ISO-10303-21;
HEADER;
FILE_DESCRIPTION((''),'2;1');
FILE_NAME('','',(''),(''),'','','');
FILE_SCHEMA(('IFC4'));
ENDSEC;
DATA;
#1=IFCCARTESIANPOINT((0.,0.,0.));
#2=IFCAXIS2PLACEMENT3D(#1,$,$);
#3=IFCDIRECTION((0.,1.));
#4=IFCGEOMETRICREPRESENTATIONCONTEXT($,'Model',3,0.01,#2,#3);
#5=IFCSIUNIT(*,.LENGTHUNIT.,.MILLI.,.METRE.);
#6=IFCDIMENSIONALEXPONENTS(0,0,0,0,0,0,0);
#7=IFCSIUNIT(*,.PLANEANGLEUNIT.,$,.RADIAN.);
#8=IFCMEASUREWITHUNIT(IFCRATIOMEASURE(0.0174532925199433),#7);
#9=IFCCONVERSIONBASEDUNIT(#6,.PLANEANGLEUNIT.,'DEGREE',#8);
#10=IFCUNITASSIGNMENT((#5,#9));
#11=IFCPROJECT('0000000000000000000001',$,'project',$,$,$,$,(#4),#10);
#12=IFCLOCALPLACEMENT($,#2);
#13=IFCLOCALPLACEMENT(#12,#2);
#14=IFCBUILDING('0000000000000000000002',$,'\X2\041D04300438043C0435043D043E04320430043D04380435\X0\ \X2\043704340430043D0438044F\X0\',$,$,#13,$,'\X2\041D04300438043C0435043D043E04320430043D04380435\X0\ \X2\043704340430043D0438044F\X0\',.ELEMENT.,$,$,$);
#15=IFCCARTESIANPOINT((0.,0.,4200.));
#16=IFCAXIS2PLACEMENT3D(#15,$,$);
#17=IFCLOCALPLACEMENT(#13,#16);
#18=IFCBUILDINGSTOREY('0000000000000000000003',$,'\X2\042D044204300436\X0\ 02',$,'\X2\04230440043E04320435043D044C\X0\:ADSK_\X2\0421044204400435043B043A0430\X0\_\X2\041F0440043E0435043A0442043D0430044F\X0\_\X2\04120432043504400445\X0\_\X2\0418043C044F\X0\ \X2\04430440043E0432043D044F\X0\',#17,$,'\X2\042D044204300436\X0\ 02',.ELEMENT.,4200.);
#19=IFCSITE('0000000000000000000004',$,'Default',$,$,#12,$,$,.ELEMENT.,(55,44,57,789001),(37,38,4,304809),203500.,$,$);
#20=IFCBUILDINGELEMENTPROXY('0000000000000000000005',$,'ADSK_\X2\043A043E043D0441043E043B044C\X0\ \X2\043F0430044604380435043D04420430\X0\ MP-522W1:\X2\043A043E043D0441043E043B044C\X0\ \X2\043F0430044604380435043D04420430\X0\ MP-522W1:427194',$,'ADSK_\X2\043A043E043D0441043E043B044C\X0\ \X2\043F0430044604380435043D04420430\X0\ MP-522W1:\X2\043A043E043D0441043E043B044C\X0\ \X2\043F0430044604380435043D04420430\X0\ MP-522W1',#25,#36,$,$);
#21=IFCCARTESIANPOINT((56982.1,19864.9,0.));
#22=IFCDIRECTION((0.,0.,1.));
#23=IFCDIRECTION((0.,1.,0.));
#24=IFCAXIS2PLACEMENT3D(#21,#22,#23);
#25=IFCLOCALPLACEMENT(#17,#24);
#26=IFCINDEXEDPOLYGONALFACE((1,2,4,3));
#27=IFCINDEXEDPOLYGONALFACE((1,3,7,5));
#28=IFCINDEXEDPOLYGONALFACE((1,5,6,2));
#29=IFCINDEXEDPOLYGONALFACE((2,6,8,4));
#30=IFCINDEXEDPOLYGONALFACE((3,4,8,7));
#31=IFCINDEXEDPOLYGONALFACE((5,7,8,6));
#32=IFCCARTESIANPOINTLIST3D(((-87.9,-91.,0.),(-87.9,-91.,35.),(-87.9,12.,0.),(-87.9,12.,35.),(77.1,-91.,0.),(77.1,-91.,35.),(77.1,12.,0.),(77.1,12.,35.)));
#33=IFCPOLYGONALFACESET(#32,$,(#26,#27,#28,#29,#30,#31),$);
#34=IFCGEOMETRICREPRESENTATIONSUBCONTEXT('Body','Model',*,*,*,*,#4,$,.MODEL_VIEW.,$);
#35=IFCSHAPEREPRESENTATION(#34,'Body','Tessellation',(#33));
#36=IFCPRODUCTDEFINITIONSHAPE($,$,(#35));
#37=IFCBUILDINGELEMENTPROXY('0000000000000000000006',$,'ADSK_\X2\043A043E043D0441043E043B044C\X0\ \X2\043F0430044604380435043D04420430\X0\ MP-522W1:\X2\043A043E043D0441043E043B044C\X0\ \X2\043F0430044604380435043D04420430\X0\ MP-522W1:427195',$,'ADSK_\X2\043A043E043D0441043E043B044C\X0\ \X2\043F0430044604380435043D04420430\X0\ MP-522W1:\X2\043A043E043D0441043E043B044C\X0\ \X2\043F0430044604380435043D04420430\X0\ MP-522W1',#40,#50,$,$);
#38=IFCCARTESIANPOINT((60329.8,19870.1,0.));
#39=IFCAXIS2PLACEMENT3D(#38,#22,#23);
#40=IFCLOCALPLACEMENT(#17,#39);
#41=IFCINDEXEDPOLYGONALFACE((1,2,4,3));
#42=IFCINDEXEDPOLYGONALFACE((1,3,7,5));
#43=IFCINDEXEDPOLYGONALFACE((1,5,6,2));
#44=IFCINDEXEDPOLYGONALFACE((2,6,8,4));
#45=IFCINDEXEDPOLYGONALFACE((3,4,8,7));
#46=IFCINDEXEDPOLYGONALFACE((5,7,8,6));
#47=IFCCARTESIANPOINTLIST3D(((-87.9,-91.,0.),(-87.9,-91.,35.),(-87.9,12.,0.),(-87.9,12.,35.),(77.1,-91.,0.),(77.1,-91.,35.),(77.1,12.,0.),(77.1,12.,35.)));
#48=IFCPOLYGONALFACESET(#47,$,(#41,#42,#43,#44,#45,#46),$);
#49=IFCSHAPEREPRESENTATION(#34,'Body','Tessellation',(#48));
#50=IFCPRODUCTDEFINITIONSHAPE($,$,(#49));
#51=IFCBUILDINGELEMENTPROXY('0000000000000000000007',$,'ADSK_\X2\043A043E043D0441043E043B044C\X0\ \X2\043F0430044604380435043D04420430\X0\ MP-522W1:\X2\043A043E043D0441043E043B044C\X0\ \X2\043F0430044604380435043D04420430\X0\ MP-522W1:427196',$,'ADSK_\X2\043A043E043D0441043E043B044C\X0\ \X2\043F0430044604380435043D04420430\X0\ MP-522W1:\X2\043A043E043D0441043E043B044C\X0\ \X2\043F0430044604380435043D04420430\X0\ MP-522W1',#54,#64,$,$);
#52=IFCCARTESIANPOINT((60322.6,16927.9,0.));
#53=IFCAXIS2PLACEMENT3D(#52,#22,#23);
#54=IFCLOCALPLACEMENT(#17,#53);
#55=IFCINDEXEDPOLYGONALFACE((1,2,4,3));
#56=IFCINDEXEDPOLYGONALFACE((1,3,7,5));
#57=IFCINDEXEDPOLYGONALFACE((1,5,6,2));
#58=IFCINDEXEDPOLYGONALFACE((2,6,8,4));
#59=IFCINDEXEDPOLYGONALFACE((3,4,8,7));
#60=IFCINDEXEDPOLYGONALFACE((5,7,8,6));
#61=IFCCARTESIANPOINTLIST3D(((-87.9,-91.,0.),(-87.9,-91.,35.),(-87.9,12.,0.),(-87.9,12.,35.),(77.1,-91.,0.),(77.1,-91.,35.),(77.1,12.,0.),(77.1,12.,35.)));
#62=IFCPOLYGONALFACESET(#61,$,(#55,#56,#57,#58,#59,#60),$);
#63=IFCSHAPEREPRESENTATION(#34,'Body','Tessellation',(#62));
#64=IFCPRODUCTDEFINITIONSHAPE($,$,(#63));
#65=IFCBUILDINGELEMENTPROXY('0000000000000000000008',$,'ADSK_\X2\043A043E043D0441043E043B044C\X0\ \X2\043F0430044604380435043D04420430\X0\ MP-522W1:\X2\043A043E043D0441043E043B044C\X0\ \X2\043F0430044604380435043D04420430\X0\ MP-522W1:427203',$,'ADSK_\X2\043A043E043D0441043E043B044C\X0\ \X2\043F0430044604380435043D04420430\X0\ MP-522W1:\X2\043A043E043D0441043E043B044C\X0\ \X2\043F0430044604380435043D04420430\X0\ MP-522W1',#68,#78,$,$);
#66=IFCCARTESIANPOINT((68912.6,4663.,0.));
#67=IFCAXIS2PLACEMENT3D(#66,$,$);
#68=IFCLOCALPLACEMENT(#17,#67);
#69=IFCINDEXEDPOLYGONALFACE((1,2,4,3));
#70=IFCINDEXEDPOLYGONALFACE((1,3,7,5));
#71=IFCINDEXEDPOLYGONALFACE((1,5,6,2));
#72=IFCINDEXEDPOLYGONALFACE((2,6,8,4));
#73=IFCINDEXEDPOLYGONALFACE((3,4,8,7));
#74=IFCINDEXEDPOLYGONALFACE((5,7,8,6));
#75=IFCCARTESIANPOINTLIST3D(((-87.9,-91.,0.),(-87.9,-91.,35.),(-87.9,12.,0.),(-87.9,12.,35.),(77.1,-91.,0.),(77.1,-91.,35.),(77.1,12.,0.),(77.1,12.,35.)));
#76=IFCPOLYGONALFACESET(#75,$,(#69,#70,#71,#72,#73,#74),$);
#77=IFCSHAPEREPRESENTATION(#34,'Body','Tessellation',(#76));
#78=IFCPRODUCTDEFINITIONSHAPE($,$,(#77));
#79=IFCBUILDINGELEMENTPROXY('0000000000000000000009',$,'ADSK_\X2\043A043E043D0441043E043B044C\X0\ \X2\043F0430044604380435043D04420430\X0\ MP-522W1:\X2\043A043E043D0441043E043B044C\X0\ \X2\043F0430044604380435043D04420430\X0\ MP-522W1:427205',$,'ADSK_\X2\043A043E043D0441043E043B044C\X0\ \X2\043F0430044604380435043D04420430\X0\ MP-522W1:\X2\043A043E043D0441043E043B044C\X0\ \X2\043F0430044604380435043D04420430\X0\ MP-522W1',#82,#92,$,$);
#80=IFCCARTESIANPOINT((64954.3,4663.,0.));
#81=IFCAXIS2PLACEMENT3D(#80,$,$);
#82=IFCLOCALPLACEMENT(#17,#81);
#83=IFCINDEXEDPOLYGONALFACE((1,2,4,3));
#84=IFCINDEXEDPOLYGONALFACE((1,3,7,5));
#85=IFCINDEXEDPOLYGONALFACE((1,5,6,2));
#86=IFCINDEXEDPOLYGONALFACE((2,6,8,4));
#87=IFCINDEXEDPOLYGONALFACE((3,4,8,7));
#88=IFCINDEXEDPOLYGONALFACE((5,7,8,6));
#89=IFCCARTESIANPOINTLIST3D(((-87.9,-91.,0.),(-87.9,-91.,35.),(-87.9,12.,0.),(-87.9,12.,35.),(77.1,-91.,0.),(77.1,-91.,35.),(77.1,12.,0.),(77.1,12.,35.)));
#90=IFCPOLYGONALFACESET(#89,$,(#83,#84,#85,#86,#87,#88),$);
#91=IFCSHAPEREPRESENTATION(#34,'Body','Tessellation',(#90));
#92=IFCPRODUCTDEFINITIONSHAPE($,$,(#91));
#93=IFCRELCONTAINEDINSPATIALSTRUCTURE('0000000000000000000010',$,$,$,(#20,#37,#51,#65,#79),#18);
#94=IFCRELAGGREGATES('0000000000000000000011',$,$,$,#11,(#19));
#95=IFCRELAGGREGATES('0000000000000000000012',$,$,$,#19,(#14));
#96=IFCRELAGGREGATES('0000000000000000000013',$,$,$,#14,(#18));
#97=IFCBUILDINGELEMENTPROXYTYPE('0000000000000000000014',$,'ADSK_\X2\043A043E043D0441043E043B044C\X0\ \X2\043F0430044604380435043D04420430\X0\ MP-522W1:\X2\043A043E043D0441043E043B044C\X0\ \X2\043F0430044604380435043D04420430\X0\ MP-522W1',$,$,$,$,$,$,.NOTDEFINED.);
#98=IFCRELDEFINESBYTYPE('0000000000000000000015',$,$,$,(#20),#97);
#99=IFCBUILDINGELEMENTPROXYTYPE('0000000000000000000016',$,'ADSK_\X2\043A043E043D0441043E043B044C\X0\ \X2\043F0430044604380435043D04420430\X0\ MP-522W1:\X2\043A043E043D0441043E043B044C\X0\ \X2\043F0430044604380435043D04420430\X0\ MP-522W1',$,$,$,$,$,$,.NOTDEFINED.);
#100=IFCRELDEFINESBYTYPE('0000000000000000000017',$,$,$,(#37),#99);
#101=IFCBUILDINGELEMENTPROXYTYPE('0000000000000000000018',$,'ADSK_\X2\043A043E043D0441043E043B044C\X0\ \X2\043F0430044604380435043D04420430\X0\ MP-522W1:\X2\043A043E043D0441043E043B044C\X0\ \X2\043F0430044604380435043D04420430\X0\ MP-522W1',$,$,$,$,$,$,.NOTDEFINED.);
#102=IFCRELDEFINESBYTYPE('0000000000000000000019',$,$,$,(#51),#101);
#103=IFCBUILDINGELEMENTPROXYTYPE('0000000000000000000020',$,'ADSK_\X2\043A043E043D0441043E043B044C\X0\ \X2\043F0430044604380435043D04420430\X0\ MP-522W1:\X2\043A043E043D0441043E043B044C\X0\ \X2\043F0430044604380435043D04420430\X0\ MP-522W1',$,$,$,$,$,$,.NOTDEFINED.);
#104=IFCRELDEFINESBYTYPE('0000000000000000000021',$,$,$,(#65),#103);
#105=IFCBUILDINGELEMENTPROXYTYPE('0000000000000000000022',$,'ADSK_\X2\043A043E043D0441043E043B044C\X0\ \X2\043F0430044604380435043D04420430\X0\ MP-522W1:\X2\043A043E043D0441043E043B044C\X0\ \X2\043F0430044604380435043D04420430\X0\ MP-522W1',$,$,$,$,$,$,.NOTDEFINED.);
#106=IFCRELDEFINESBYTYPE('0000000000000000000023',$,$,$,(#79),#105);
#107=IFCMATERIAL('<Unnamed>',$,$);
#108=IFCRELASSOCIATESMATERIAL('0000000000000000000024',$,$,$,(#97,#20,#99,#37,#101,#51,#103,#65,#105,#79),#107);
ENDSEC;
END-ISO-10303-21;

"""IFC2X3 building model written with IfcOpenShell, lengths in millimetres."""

from ifc_helpers import new_model, entity, si_unit, converted_unit, direction, frame, origin, origin_2d_with_axis, place, context, subcontext, project, spatial, rectangle, extrude, source, transform, mapped, material, type_object, type_shapes, element, save


model = new_model("IFC2X3")

# Units and contexts
model_context = context("Model", 3, precision=0.01, world=origin(), true_north=direction((0.0, 1.0)))
body_context = subcontext(model_context, "Body", "Model", "MODEL_VIEW")
ifc_project = project(units=[si_unit("LENGTHUNIT", "METRE", prefix="MILLI"), converted_unit("PLANEANGLEUNIT", "DEGREE", entity("IfcRatioMeasure", 0.0174532925199433), si_unit("PLANEANGLEUNIT", "RADIAN"), dimensions=[0, 0, 0, 0, 0, 0, 0])], contexts=[model_context])

# Site, building, storey
site_placement = place(None, origin())
site = spatial("IfcSite", under=ifc_project, at=site_placement, Name="Default", CompositionType="ELEMENT", RefLatitude=(55, 44, 57, 789001), RefLongitude=(37, 38, 4, 304809), RefElevation=203500.0)
building_placement = place(site_placement, origin())
building = spatial("IfcBuilding", under=site, at=building_placement, Name="Наименование здания", LongName="Наименование здания", CompositionType="ELEMENT")
storey_placement = place(building_placement, frame((0.0, 0.0, 4200.0)))
storey = spatial("IfcBuildingStorey", under=building, at=storey_placement, Name="Этаж 02", ObjectType="Уровень:ADSK_Стрелка_Проектная_Вверх_Имя уровня", LongName="Этаж 02", CompositionType="ELEMENT", Elevation=4200.0)

# Building element proxies
ifc_material = material(Name="<Unnamed>")
building_element_proxy_type_1 = type_object("IfcBuildingElementProxyType", Name="ADSK_консоль пациента MP-522W1:консоль пациента MP-522W1", PredefinedType="NOTDEFINED", material=ifc_material)
shared_shape_1 = source(origin(), body_context, "Body", "SweptSolid", [
    extrude(rectangle(XDim=165.0, YDim=103.0, at=origin_2d_with_axis()), frame((-5.4, -39.5, 0.0), z_axis=(0.0, 0.0, 1.0), x_axis=(-1.0, 0.0, 0.0)), (0.0, 0.0, 1.0), 35.0),
])
type_shapes(building_element_proxy_type_1, [shared_shape_1])
proxy_1_placement = place(storey_placement, frame((56982.1, 19864.9, 0.0), z_axis=(0.0, 0.0, 1.0), x_axis=(0.0, 1.0, 0.0)))
element("IfcBuildingElementProxy", 1, at=proxy_1_placement, inside=storey, type_object=building_element_proxy_type_1, material=ifc_material, Name="ADSK_консоль пациента MP-522W1:консоль пациента MP-522W1:427194", ObjectType="ADSK_консоль пациента MP-522W1:консоль пациента MP-522W1", context=body_context, shape_type="MappedRepresentation", body=[
    mapped(shared_shape_1, transform((0.0, 0.0, 0.0), scale=1.0)),
])
building_element_proxy_type_2 = type_object("IfcBuildingElementProxyType", Name="ADSK_консоль пациента MP-522W1:консоль пациента MP-522W1", PredefinedType="NOTDEFINED", material=ifc_material)
type_shapes(building_element_proxy_type_2, [shared_shape_1])
proxy_2_placement = place(storey_placement, frame((60329.8, 19870.1, 0.0), z_axis=(0.0, 0.0, 1.0), x_axis=(0.0, 1.0, 0.0)))
element("IfcBuildingElementProxy", 2, at=proxy_2_placement, inside=storey, type_object=building_element_proxy_type_2, material=ifc_material, Name="ADSK_консоль пациента MP-522W1:консоль пациента MP-522W1:427195", ObjectType="ADSK_консоль пациента MP-522W1:консоль пациента MP-522W1", context=body_context, shape_type="MappedRepresentation", body=[
    mapped(shared_shape_1, transform((0.0, 0.0, 0.0), scale=1.0)),
])
building_element_proxy_type_3 = type_object("IfcBuildingElementProxyType", Name="ADSK_консоль пациента MP-522W1:консоль пациента MP-522W1", PredefinedType="NOTDEFINED", material=ifc_material)
type_shapes(building_element_proxy_type_3, [shared_shape_1])
proxy_3_placement = place(storey_placement, frame((60322.6, 16927.9, 0.0), z_axis=(0.0, 0.0, 1.0), x_axis=(0.0, 1.0, 0.0)))
element("IfcBuildingElementProxy", 3, at=proxy_3_placement, inside=storey, type_object=building_element_proxy_type_3, material=ifc_material, Name="ADSK_консоль пациента MP-522W1:консоль пациента MP-522W1:427196", ObjectType="ADSK_консоль пациента MP-522W1:консоль пациента MP-522W1", context=body_context, shape_type="MappedRepresentation", body=[
    mapped(shared_shape_1, transform((0.0, 0.0, 0.0), scale=1.0)),
])
building_element_proxy_type_4 = type_object("IfcBuildingElementProxyType", Name="ADSK_консоль пациента MP-522W1:консоль пациента MP-522W1", PredefinedType="NOTDEFINED", material=ifc_material)
type_shapes(building_element_proxy_type_4, [shared_shape_1])
proxy_4_placement = place(storey_placement, frame((68912.6, 4663.0, 0.0)))
element("IfcBuildingElementProxy", 4, at=proxy_4_placement, inside=storey, type_object=building_element_proxy_type_4, material=ifc_material, Name="ADSK_консоль пациента MP-522W1:консоль пациента MP-522W1:427203", ObjectType="ADSK_консоль пациента MP-522W1:консоль пациента MP-522W1", context=body_context, shape_type="MappedRepresentation", body=[
    mapped(shared_shape_1, transform((0.0, 0.0, 0.0), scale=1.0)),
])
building_element_proxy_type_5 = type_object("IfcBuildingElementProxyType", Name="ADSK_консоль пациента MP-522W1:консоль пациента MP-522W1", PredefinedType="NOTDEFINED", material=ifc_material)
type_shapes(building_element_proxy_type_5, [shared_shape_1])
proxy_5_placement = place(storey_placement, frame((64954.3, 4663.0, 0.0)))
element("IfcBuildingElementProxy", 5, at=proxy_5_placement, inside=storey, type_object=building_element_proxy_type_5, material=ifc_material, Name="ADSK_консоль пациента MP-522W1:консоль пациента MP-522W1:427205", ObjectType="ADSK_консоль пациента MP-522W1:консоль пациента MP-522W1", context=body_context, shape_type="MappedRepresentation", body=[
    mapped(shared_shape_1, transform((0.0, 0.0, 0.0), scale=1.0)),
])

save(model, "model.ifc")
